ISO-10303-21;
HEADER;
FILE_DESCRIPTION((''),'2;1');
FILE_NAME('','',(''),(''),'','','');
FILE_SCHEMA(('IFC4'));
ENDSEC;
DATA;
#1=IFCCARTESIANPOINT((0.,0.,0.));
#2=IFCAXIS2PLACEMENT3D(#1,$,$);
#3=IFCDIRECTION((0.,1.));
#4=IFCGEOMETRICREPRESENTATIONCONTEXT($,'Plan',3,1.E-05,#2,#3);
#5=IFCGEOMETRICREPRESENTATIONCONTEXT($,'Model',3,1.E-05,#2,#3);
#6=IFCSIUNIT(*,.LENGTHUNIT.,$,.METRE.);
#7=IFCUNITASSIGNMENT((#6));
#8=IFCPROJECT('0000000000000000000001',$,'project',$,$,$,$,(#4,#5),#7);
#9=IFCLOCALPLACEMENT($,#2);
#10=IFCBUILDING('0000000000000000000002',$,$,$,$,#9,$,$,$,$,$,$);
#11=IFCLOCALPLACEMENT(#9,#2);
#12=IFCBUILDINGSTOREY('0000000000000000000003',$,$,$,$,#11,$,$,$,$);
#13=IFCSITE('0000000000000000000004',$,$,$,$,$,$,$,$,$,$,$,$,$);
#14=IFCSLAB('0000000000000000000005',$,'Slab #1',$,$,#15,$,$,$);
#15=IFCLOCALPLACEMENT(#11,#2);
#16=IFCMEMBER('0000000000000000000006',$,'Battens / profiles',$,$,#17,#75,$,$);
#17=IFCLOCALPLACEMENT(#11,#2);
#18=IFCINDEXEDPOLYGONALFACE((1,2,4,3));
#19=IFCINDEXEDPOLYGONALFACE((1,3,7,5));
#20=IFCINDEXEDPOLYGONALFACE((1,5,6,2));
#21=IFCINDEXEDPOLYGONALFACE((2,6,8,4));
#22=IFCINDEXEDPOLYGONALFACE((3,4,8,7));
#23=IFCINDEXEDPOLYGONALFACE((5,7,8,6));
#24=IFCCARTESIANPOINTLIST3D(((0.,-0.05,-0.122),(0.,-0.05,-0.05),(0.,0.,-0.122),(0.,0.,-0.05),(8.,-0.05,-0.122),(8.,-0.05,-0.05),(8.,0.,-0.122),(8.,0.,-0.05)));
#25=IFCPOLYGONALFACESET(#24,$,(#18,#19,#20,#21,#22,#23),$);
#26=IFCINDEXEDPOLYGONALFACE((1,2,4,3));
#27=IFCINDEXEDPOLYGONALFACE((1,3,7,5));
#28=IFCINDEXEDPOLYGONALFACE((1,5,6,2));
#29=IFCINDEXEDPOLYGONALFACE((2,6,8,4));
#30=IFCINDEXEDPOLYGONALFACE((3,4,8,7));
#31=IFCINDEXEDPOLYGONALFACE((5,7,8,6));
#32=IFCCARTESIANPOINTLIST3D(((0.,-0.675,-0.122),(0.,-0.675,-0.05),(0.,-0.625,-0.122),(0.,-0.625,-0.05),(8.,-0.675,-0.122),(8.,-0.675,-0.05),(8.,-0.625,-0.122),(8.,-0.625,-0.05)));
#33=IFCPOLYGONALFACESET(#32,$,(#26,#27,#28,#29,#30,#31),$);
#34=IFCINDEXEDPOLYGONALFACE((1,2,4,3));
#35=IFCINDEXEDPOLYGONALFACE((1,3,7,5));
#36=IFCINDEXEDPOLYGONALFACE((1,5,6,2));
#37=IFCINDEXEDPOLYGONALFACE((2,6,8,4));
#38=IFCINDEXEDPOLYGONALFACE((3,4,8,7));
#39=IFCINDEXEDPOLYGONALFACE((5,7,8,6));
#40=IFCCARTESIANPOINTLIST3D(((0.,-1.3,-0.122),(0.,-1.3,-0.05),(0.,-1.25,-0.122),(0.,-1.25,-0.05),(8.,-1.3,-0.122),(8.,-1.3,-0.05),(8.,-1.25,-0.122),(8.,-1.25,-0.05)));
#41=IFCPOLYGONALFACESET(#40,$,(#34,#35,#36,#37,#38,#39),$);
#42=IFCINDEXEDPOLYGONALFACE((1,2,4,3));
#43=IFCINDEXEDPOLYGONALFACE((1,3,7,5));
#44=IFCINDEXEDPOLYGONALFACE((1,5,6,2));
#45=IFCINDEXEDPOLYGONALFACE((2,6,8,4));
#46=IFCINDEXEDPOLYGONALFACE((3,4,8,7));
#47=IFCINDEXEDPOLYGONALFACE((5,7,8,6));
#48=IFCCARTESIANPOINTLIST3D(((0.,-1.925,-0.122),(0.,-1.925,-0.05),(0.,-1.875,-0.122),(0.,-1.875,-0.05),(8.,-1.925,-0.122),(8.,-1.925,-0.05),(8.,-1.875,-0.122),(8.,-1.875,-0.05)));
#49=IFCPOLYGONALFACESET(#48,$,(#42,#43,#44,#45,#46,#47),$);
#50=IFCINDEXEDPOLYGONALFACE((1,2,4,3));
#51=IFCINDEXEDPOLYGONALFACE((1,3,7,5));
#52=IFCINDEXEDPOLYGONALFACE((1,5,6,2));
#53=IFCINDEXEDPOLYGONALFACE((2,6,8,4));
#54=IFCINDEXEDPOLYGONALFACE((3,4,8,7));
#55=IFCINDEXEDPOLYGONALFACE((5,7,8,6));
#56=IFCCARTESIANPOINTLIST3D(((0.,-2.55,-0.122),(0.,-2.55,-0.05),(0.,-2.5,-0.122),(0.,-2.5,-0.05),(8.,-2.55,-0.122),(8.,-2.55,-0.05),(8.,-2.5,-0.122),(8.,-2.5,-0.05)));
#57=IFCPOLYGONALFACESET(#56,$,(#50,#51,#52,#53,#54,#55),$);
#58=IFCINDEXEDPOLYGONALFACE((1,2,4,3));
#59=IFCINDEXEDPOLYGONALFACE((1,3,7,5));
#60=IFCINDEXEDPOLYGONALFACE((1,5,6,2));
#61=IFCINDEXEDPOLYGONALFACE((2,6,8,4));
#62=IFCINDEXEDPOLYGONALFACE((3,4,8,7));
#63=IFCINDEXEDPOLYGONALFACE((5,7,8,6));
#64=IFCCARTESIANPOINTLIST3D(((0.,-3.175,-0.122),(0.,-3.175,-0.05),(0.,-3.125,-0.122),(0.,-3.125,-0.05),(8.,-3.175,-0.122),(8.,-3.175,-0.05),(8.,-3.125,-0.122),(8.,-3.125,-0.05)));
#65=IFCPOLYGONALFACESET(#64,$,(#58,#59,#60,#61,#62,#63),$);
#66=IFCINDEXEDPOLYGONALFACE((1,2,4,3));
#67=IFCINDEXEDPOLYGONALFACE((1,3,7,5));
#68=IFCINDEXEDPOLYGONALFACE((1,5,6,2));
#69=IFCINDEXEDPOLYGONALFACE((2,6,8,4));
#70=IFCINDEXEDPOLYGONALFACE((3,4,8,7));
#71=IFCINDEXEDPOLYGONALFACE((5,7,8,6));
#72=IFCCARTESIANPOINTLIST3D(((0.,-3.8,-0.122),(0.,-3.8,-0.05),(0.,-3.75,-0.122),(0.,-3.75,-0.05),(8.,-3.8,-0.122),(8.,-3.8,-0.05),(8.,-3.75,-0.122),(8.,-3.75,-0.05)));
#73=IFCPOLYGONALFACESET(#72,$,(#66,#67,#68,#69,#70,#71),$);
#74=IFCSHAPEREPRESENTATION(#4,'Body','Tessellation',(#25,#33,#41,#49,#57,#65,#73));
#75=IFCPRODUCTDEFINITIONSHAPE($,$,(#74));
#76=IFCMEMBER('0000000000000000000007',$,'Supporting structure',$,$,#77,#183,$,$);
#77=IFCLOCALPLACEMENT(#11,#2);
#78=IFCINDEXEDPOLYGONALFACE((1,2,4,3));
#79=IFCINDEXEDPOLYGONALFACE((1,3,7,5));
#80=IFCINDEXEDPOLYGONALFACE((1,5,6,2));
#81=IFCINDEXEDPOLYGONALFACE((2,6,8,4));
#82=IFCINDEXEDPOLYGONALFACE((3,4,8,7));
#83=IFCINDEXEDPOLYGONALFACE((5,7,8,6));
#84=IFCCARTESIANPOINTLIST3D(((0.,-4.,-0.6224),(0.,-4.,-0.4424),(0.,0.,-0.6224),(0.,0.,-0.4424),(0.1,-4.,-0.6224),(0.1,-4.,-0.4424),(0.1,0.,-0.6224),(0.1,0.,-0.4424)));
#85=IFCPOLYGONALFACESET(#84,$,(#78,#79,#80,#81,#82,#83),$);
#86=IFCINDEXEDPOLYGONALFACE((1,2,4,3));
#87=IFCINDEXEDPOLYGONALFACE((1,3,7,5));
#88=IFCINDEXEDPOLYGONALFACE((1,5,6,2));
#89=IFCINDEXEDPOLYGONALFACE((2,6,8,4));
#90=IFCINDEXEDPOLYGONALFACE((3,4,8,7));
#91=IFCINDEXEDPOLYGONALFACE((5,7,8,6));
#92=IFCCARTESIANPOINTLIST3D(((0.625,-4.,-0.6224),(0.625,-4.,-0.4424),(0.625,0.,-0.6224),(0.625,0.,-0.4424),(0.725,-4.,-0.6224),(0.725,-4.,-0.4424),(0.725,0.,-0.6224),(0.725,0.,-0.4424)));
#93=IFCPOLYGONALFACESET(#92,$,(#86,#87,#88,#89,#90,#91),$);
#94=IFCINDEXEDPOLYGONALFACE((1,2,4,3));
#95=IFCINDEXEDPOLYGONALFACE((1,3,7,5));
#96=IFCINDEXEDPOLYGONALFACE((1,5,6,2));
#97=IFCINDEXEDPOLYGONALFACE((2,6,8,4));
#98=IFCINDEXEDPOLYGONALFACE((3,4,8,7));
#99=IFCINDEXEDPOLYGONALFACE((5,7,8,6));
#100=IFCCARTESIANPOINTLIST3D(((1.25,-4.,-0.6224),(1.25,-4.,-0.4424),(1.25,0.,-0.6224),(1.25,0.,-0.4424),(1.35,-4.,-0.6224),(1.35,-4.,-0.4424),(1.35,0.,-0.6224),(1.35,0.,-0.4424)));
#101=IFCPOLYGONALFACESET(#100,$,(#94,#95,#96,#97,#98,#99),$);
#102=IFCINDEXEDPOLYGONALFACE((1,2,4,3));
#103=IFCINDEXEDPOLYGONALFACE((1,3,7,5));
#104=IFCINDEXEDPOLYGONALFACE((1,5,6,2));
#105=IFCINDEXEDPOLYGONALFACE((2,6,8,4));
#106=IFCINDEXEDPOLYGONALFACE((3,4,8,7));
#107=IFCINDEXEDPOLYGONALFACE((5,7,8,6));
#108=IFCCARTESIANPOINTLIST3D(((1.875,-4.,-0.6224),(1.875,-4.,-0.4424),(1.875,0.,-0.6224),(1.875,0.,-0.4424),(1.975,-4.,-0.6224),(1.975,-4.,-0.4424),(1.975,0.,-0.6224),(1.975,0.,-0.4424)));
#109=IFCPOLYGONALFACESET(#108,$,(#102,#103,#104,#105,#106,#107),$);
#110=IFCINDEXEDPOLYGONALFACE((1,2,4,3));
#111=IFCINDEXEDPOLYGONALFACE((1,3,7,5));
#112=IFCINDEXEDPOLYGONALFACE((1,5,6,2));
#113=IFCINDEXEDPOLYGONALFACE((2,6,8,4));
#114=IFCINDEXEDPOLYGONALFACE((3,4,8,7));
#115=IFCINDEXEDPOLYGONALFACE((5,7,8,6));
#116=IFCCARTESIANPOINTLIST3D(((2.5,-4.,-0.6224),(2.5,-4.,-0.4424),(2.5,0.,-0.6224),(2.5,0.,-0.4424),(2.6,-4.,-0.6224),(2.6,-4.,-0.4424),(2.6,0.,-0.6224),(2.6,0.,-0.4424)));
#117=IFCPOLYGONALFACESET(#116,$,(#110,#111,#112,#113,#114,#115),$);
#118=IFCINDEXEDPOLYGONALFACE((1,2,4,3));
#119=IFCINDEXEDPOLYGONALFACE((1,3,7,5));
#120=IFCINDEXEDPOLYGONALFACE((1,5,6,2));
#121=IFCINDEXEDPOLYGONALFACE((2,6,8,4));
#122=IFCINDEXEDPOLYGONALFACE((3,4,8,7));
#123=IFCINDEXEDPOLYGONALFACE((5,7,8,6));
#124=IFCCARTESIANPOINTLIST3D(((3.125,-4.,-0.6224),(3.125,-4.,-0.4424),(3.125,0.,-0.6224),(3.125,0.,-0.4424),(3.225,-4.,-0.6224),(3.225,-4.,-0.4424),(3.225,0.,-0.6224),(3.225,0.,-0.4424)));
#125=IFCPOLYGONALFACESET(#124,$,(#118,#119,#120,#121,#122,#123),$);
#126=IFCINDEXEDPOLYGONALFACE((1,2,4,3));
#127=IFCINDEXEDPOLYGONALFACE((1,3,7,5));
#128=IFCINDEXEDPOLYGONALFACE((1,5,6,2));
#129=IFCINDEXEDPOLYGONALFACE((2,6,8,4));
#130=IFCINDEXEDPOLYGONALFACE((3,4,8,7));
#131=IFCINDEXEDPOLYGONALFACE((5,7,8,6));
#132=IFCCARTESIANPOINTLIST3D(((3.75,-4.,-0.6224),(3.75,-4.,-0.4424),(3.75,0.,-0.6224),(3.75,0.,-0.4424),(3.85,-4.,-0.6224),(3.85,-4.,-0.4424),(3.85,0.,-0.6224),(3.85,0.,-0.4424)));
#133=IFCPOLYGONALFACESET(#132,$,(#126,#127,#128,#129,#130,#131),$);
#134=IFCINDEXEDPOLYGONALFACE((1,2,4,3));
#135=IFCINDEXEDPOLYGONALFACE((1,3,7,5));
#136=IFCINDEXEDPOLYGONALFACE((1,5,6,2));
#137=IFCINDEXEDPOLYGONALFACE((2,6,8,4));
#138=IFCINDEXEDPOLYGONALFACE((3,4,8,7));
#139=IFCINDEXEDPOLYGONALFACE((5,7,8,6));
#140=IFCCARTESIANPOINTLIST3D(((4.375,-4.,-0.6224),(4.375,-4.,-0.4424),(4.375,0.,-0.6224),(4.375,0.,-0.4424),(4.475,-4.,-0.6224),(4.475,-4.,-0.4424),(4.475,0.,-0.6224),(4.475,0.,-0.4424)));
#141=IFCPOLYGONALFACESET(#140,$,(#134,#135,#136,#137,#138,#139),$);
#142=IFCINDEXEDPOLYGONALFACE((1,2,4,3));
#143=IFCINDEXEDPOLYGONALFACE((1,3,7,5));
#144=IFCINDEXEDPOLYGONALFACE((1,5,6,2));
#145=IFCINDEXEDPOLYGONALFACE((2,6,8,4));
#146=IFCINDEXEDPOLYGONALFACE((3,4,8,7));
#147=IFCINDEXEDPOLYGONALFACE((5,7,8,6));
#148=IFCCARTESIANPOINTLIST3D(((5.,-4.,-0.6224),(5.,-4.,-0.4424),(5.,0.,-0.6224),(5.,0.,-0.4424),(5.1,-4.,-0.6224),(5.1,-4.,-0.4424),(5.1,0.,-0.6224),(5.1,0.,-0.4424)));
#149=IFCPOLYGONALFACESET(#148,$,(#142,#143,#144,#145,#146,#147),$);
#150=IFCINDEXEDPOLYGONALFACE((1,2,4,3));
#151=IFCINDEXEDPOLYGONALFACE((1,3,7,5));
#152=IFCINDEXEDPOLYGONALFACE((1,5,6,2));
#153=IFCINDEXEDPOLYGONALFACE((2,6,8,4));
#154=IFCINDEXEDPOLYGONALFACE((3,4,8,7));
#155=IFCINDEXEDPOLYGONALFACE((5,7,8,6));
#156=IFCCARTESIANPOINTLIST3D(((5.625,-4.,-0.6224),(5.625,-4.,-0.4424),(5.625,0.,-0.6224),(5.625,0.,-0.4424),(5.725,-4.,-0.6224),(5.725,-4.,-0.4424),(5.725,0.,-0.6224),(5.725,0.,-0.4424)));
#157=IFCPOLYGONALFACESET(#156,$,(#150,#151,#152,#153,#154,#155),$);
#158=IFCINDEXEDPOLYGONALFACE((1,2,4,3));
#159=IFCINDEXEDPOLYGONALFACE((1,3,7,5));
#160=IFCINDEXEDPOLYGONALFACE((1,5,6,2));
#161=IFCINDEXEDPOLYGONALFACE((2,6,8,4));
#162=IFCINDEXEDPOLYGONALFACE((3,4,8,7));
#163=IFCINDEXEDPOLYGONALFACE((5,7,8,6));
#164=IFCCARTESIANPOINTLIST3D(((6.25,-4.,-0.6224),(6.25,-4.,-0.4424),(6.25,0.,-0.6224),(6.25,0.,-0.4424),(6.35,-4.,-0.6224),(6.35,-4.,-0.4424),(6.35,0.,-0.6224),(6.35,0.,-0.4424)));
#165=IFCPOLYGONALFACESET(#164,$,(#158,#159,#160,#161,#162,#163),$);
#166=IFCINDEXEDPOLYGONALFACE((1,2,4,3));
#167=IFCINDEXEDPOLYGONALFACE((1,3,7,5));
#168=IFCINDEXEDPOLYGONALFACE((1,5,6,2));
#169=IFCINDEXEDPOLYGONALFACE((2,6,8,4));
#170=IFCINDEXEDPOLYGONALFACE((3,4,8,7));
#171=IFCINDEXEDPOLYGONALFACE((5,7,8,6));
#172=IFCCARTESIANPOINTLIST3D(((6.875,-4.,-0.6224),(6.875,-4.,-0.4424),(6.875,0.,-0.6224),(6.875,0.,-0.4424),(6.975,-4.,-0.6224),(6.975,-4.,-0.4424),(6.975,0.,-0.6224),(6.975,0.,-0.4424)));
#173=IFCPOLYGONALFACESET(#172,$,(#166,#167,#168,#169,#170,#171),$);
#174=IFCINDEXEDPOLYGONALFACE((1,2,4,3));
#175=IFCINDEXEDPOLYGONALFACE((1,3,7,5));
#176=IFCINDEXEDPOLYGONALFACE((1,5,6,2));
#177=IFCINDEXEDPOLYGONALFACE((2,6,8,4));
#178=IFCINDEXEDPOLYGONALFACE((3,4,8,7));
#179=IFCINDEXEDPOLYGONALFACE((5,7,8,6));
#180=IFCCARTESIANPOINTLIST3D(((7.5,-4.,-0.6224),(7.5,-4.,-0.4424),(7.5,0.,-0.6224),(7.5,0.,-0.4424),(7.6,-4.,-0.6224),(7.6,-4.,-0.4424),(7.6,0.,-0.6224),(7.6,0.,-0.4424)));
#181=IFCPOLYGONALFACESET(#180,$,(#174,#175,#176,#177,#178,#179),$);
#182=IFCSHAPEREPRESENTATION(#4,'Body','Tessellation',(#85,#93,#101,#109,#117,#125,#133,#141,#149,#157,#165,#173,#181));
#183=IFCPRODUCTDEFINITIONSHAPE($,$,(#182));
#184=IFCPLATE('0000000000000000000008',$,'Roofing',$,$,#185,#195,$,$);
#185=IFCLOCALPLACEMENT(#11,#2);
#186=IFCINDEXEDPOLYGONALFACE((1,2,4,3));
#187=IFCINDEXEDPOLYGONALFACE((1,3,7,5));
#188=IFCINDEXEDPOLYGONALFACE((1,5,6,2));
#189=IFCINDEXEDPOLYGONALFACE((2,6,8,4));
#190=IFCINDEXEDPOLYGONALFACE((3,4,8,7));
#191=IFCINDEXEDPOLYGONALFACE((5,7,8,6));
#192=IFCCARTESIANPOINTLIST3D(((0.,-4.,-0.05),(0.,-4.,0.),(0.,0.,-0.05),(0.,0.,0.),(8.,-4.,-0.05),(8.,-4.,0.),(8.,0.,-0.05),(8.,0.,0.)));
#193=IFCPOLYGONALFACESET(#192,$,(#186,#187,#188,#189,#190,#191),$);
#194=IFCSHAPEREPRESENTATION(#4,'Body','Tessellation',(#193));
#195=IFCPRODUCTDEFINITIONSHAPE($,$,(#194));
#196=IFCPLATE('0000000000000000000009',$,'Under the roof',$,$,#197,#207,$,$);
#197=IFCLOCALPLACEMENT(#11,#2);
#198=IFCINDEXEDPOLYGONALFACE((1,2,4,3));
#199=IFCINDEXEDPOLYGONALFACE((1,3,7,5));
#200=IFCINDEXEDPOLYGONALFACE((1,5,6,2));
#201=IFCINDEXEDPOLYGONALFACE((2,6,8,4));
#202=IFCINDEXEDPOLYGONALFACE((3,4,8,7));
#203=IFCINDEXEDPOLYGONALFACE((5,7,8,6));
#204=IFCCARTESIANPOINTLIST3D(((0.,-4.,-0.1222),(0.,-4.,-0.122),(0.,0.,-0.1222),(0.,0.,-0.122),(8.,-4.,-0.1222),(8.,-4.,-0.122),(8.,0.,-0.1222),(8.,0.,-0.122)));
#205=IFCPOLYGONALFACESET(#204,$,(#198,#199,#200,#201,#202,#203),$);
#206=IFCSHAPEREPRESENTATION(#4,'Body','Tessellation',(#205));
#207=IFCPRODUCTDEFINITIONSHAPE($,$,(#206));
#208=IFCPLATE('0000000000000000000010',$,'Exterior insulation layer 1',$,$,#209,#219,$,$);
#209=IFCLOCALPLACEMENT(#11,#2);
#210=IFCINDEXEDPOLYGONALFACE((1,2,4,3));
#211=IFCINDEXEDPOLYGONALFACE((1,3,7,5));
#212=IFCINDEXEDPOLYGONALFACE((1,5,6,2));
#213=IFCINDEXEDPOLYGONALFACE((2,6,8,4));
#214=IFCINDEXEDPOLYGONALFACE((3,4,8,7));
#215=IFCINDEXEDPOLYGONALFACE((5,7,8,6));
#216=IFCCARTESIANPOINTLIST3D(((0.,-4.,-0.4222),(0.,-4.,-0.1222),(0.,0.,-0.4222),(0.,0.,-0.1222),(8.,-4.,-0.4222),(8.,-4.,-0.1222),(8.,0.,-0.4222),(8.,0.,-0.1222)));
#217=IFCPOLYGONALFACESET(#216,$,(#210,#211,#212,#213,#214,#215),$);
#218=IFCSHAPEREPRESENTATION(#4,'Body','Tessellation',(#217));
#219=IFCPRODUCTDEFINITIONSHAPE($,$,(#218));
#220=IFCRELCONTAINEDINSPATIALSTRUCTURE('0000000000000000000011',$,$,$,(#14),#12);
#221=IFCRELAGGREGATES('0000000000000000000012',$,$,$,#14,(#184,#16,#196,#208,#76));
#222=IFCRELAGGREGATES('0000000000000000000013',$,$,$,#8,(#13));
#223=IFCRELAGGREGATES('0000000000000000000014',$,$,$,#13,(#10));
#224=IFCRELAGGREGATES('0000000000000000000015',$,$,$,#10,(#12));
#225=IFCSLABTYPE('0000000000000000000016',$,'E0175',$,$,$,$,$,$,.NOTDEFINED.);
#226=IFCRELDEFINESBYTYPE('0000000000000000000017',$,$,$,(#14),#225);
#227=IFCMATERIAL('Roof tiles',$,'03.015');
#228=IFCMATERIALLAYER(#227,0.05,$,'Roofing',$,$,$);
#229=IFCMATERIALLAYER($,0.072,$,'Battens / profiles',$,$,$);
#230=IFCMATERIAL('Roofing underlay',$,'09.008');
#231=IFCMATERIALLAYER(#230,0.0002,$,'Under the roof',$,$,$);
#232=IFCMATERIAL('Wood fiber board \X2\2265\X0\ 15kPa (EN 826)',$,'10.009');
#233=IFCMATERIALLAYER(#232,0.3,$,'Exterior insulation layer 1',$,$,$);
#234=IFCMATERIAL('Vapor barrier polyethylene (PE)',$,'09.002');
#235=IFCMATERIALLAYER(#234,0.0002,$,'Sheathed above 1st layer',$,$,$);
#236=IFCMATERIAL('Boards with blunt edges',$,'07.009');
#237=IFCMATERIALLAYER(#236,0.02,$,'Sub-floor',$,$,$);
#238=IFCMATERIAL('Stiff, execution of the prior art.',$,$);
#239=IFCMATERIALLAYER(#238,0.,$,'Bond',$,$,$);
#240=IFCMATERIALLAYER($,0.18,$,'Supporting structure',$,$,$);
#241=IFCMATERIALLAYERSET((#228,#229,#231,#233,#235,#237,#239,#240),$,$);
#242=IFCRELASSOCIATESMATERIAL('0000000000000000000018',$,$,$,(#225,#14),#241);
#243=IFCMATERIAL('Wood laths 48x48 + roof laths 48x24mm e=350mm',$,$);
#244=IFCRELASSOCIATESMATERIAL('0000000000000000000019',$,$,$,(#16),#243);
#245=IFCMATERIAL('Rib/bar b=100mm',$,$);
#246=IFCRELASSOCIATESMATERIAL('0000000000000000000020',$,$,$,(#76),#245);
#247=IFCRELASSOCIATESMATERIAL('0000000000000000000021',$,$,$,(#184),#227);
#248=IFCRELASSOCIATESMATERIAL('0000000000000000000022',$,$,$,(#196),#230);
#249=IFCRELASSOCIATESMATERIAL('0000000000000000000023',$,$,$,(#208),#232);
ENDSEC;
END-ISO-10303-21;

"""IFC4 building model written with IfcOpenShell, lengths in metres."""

from ifc_helpers import new_model, si_unit, direction, frame, frame_2d, origin, origin_with_axes, place, context, project, spatial, rectangle, extrude, material, layer, layer_set, type_object, element, aggregate, save


model = new_model("IFC4")

# Units and contexts
plan_context = context("Plan", 3, precision=1e-05, world=origin(), true_north=direction((0.0, 1.0)))
model_context = context("Model", 3, precision=1e-05, world=origin(), true_north=direction((0.0, 1.0)))
ifc_project = project(units=[si_unit("LENGTHUNIT", "METRE")], contexts=[plan_context, model_context])

# Site, building, storey
site = spatial("IfcSite", under=ifc_project)
building_placement = place(None, origin())
building = spatial("IfcBuilding", under=site, at=building_placement)
storey_placement = place(building_placement, origin())
storey = spatial("IfcBuildingStorey", under=building, at=storey_placement)

# Slab, members, plates
ifc_material_1 = material(Name="Roof tiles", Category="03.015")
ifc_layer_1 = layer(ifc_material_1, 0.05, Name="Roofing")
ifc_layer_2 = layer(None, 0.072, Name="Battens / profiles")
ifc_material_2 = material(Name="Roofing underlay", Category="09.008")
ifc_layer_3 = layer(ifc_material_2, 0.0002, Name="Under the roof")
ifc_material_3 = material(Name="Wood fiber board ≥ 15kPa (EN 826)", Category="10.009")
ifc_layer_4 = layer(ifc_material_3, 0.3, Name="Exterior insulation layer 1")
ifc_material_4 = material(Name="Vapor barrier polyethylene (PE)", Category="09.002")
ifc_layer_5 = layer(ifc_material_4, 0.0002, Name="Sheathed above 1st layer")
ifc_material_5 = material(Name="Boards with blunt edges", Category="07.009")
ifc_layer_6 = layer(ifc_material_5, 0.02, Name="Sub-floor")
ifc_material_6 = material(Name="Stiff, execution of the prior art.")
ifc_layer_7 = layer(ifc_material_6, 0.0, Name="Bond")
ifc_layer_8 = layer(None, 0.18, Name="Supporting structure")
ifc_layer_set = layer_set([ifc_layer_1, ifc_layer_2, ifc_layer_3, ifc_layer_4, ifc_layer_5, ifc_layer_6, ifc_layer_7, ifc_layer_8])
slab_type = type_object("IfcSlabType", Name="E0175", PredefinedType="NOTDEFINED", material=ifc_layer_set)
slab_placement = place(None, frame((0.0, 0.0, 0.0), z_axis=(0.0, 0.0, -1.0), x_axis=(1.0, 0.0, 0.0)))
slab = element("IfcSlab", 1, at=slab_placement, inside=storey, type_object=slab_type, material=ifc_layer_set, Name="Slab #1")
ifc_material_7 = material(Name="Wood laths 48x48 + roof laths 48x24mm e=350mm")
member_1_placement = place(slab_placement, origin())
member_1 = element("IfcMember", 2, at=member_1_placement, material=ifc_material_7, Name="Battens / profiles", context=plan_context, shape_type="SweptSolid", body=[
    extrude(rectangle(XDim=0.05, YDim=0.072, at=frame_2d((0.025, 0.036), x_axis=(1.0, 0.0))), frame((0.0, 0.0, 0.05), z_axis=(1.0, 0.0, 0.0), x_axis=(0.0, 1.0, 0.0)), (0.0, 0.0, 1.0), 8.0),
    extrude(rectangle(XDim=0.05, YDim=0.072, at=frame_2d((0.025, 0.036), x_axis=(1.0, 0.0))), frame((0.0, 0.625, 0.05), z_axis=(1.0, 0.0, 0.0), x_axis=(0.0, 1.0, 0.0)), (0.0, 0.0, 1.0), 8.0),
    extrude(rectangle(XDim=0.05, YDim=0.072, at=frame_2d((0.025, 0.036), x_axis=(1.0, 0.0))), frame((0.0, 1.25, 0.05), z_axis=(1.0, 0.0, 0.0), x_axis=(0.0, 1.0, 0.0)), (0.0, 0.0, 1.0), 8.0),
    extrude(rectangle(XDim=0.05, YDim=0.072, at=frame_2d((0.025, 0.036), x_axis=(1.0, 0.0))), frame((0.0, 1.875, 0.05), z_axis=(1.0, 0.0, 0.0), x_axis=(0.0, 1.0, 0.0)), (0.0, 0.0, 1.0), 8.0),
    extrude(rectangle(XDim=0.05, YDim=0.072, at=frame_2d((0.025, 0.036), x_axis=(1.0, 0.0))), frame((0.0, 2.5, 0.05), z_axis=(1.0, 0.0, 0.0), x_axis=(0.0, 1.0, 0.0)), (0.0, 0.0, 1.0), 8.0),
    extrude(rectangle(XDim=0.05, YDim=0.072, at=frame_2d((0.025, 0.036), x_axis=(1.0, 0.0))), frame((0.0, 3.125, 0.05), z_axis=(1.0, 0.0, 0.0), x_axis=(0.0, 1.0, 0.0)), (0.0, 0.0, 1.0), 8.0),
    extrude(rectangle(XDim=0.05, YDim=0.072, at=frame_2d((0.025, 0.036), x_axis=(1.0, 0.0))), frame((0.0, 3.75, 0.05), z_axis=(1.0, 0.0, 0.0), x_axis=(0.0, 1.0, 0.0)), (0.0, 0.0, 1.0), 8.0),
])
ifc_material_8 = material(Name="Rib/bar b=100mm")
member_2_placement = place(slab_placement, origin())
member_2 = element("IfcMember", 3, at=member_2_placement, material=ifc_material_8, Name="Supporting structure", context=plan_context, shape_type="SweptSolid", body=[
    extrude(rectangle(XDim=0.1, YDim=0.18, at=frame_2d((0.05, 0.09), x_axis=(1.0, 0.0))), frame((0.0, 4.0, 0.4424), z_axis=(0.0, -1.0, 0.0), x_axis=(1.0, 0.0, 0.0)), (0.0, 0.0, 1.0), 4.0),
    extrude(rectangle(XDim=0.1, YDim=0.18, at=frame_2d((0.05, 0.09), x_axis=(1.0, 0.0))), frame((0.625, 4.0, 0.4424), z_axis=(0.0, -1.0, 0.0), x_axis=(1.0, 0.0, 0.0)), (0.0, 0.0, 1.0), 4.0),
    extrude(rectangle(XDim=0.1, YDim=0.18, at=frame_2d((0.05, 0.09), x_axis=(1.0, 0.0))), frame((1.25, 4.0, 0.4424), z_axis=(0.0, -1.0, 0.0), x_axis=(1.0, 0.0, 0.0)), (0.0, 0.0, 1.0), 4.0),
    extrude(rectangle(XDim=0.1, YDim=0.18, at=frame_2d((0.05, 0.09), x_axis=(1.0, 0.0))), frame((1.875, 4.0, 0.4424), z_axis=(0.0, -1.0, 0.0), x_axis=(1.0, 0.0, 0.0)), (0.0, 0.0, 1.0), 4.0),
    extrude(rectangle(XDim=0.1, YDim=0.18, at=frame_2d((0.05, 0.09), x_axis=(1.0, 0.0))), frame((2.5, 4.0, 0.4424), z_axis=(0.0, -1.0, 0.0), x_axis=(1.0, 0.0, 0.0)), (0.0, 0.0, 1.0), 4.0),
    extrude(rectangle(XDim=0.1, YDim=0.18, at=frame_2d((0.05, 0.09), x_axis=(1.0, 0.0))), frame((3.125, 4.0, 0.4424), z_axis=(0.0, -1.0, 0.0), x_axis=(1.0, 0.0, 0.0)), (0.0, 0.0, 1.0), 4.0),
    extrude(rectangle(XDim=0.1, YDim=0.18, at=frame_2d((0.05, 0.09), x_axis=(1.0, 0.0))), frame((3.75, 4.0, 0.4424), z_axis=(0.0, -1.0, 0.0), x_axis=(1.0, 0.0, 0.0)), (0.0, 0.0, 1.0), 4.0),
    extrude(rectangle(XDim=0.1, YDim=0.18, at=frame_2d((0.05, 0.09), x_axis=(1.0, 0.0))), frame((4.375, 4.0, 0.4424), z_axis=(0.0, -1.0, 0.0), x_axis=(1.0, 0.0, 0.0)), (0.0, 0.0, 1.0), 4.0),
    extrude(rectangle(XDim=0.1, YDim=0.18, at=frame_2d((0.05, 0.09), x_axis=(1.0, 0.0))), frame((5.0, 4.0, 0.4424), z_axis=(0.0, -1.0, 0.0), x_axis=(1.0, 0.0, 0.0)), (0.0, 0.0, 1.0), 4.0),
    extrude(rectangle(XDim=0.1, YDim=0.18, at=frame_2d((0.05, 0.09), x_axis=(1.0, 0.0))), frame((5.625, 4.0, 0.4424), z_axis=(0.0, -1.0, 0.0), x_axis=(1.0, 0.0, 0.0)), (0.0, 0.0, 1.0), 4.0),
    extrude(rectangle(XDim=0.1, YDim=0.18, at=frame_2d((0.05, 0.09), x_axis=(1.0, 0.0))), frame((6.25, 4.0, 0.4424), z_axis=(0.0, -1.0, 0.0), x_axis=(1.0, 0.0, 0.0)), (0.0, 0.0, 1.0), 4.0),
    extrude(rectangle(XDim=0.1, YDim=0.18, at=frame_2d((0.05, 0.09), x_axis=(1.0, 0.0))), frame((6.875, 4.0, 0.4424), z_axis=(0.0, -1.0, 0.0), x_axis=(1.0, 0.0, 0.0)), (0.0, 0.0, 1.0), 4.0),
    extrude(rectangle(XDim=0.1, YDim=0.18, at=frame_2d((0.05, 0.09), x_axis=(1.0, 0.0))), frame((7.5, 4.0, 0.4424), z_axis=(0.0, -1.0, 0.0), x_axis=(1.0, 0.0, 0.0)), (0.0, 0.0, 1.0), 4.0),
])
plate_1_placement = place(slab_placement, origin())
plate_1 = element("IfcPlate", 4, at=plate_1_placement, material=ifc_material_1, Name="Roofing", context=plan_context, shape_type="SweptSolid", body=[
    extrude(rectangle(XDim=8.0, YDim=4.0, at=frame_2d((4.0, 2.0), x_axis=(1.0, 0.0))), origin_with_axes(), (0.0, 0.0, 1.0), 0.05),
])
plate_2_placement = place(slab_placement, origin())
plate_2 = element("IfcPlate", 5, at=plate_2_placement, material=ifc_material_2, Name="Under the roof", context=plan_context, shape_type="SweptSolid", body=[
    extrude(rectangle(XDim=8.0, YDim=4.0, at=frame_2d((4.0, 2.0), x_axis=(1.0, 0.0))), frame((0.0, 0.0, 0.122), z_axis=(0.0, 0.0, 1.0), x_axis=(1.0, 0.0, 0.0)), (0.0, 0.0, 1.0), 0.0002),
])
plate_3_placement = place(slab_placement, origin())
plate_3 = element("IfcPlate", 6, at=plate_3_placement, material=ifc_material_3, Name="Exterior insulation layer 1", context=plan_context, shape_type="SweptSolid", body=[
    extrude(rectangle(XDim=8.0, YDim=4.0, at=frame_2d((4.0, 2.0), x_axis=(1.0, 0.0))), frame((0.0, 0.0, 0.1222), z_axis=(0.0, 0.0, 1.0), x_axis=(1.0, 0.0, 0.0)), (0.0, 0.0, 1.0), 0.3),
])
aggregate(slab, [plate_1, member_1, plate_2, plate_3, member_2])

save(model, "model.ifc")
